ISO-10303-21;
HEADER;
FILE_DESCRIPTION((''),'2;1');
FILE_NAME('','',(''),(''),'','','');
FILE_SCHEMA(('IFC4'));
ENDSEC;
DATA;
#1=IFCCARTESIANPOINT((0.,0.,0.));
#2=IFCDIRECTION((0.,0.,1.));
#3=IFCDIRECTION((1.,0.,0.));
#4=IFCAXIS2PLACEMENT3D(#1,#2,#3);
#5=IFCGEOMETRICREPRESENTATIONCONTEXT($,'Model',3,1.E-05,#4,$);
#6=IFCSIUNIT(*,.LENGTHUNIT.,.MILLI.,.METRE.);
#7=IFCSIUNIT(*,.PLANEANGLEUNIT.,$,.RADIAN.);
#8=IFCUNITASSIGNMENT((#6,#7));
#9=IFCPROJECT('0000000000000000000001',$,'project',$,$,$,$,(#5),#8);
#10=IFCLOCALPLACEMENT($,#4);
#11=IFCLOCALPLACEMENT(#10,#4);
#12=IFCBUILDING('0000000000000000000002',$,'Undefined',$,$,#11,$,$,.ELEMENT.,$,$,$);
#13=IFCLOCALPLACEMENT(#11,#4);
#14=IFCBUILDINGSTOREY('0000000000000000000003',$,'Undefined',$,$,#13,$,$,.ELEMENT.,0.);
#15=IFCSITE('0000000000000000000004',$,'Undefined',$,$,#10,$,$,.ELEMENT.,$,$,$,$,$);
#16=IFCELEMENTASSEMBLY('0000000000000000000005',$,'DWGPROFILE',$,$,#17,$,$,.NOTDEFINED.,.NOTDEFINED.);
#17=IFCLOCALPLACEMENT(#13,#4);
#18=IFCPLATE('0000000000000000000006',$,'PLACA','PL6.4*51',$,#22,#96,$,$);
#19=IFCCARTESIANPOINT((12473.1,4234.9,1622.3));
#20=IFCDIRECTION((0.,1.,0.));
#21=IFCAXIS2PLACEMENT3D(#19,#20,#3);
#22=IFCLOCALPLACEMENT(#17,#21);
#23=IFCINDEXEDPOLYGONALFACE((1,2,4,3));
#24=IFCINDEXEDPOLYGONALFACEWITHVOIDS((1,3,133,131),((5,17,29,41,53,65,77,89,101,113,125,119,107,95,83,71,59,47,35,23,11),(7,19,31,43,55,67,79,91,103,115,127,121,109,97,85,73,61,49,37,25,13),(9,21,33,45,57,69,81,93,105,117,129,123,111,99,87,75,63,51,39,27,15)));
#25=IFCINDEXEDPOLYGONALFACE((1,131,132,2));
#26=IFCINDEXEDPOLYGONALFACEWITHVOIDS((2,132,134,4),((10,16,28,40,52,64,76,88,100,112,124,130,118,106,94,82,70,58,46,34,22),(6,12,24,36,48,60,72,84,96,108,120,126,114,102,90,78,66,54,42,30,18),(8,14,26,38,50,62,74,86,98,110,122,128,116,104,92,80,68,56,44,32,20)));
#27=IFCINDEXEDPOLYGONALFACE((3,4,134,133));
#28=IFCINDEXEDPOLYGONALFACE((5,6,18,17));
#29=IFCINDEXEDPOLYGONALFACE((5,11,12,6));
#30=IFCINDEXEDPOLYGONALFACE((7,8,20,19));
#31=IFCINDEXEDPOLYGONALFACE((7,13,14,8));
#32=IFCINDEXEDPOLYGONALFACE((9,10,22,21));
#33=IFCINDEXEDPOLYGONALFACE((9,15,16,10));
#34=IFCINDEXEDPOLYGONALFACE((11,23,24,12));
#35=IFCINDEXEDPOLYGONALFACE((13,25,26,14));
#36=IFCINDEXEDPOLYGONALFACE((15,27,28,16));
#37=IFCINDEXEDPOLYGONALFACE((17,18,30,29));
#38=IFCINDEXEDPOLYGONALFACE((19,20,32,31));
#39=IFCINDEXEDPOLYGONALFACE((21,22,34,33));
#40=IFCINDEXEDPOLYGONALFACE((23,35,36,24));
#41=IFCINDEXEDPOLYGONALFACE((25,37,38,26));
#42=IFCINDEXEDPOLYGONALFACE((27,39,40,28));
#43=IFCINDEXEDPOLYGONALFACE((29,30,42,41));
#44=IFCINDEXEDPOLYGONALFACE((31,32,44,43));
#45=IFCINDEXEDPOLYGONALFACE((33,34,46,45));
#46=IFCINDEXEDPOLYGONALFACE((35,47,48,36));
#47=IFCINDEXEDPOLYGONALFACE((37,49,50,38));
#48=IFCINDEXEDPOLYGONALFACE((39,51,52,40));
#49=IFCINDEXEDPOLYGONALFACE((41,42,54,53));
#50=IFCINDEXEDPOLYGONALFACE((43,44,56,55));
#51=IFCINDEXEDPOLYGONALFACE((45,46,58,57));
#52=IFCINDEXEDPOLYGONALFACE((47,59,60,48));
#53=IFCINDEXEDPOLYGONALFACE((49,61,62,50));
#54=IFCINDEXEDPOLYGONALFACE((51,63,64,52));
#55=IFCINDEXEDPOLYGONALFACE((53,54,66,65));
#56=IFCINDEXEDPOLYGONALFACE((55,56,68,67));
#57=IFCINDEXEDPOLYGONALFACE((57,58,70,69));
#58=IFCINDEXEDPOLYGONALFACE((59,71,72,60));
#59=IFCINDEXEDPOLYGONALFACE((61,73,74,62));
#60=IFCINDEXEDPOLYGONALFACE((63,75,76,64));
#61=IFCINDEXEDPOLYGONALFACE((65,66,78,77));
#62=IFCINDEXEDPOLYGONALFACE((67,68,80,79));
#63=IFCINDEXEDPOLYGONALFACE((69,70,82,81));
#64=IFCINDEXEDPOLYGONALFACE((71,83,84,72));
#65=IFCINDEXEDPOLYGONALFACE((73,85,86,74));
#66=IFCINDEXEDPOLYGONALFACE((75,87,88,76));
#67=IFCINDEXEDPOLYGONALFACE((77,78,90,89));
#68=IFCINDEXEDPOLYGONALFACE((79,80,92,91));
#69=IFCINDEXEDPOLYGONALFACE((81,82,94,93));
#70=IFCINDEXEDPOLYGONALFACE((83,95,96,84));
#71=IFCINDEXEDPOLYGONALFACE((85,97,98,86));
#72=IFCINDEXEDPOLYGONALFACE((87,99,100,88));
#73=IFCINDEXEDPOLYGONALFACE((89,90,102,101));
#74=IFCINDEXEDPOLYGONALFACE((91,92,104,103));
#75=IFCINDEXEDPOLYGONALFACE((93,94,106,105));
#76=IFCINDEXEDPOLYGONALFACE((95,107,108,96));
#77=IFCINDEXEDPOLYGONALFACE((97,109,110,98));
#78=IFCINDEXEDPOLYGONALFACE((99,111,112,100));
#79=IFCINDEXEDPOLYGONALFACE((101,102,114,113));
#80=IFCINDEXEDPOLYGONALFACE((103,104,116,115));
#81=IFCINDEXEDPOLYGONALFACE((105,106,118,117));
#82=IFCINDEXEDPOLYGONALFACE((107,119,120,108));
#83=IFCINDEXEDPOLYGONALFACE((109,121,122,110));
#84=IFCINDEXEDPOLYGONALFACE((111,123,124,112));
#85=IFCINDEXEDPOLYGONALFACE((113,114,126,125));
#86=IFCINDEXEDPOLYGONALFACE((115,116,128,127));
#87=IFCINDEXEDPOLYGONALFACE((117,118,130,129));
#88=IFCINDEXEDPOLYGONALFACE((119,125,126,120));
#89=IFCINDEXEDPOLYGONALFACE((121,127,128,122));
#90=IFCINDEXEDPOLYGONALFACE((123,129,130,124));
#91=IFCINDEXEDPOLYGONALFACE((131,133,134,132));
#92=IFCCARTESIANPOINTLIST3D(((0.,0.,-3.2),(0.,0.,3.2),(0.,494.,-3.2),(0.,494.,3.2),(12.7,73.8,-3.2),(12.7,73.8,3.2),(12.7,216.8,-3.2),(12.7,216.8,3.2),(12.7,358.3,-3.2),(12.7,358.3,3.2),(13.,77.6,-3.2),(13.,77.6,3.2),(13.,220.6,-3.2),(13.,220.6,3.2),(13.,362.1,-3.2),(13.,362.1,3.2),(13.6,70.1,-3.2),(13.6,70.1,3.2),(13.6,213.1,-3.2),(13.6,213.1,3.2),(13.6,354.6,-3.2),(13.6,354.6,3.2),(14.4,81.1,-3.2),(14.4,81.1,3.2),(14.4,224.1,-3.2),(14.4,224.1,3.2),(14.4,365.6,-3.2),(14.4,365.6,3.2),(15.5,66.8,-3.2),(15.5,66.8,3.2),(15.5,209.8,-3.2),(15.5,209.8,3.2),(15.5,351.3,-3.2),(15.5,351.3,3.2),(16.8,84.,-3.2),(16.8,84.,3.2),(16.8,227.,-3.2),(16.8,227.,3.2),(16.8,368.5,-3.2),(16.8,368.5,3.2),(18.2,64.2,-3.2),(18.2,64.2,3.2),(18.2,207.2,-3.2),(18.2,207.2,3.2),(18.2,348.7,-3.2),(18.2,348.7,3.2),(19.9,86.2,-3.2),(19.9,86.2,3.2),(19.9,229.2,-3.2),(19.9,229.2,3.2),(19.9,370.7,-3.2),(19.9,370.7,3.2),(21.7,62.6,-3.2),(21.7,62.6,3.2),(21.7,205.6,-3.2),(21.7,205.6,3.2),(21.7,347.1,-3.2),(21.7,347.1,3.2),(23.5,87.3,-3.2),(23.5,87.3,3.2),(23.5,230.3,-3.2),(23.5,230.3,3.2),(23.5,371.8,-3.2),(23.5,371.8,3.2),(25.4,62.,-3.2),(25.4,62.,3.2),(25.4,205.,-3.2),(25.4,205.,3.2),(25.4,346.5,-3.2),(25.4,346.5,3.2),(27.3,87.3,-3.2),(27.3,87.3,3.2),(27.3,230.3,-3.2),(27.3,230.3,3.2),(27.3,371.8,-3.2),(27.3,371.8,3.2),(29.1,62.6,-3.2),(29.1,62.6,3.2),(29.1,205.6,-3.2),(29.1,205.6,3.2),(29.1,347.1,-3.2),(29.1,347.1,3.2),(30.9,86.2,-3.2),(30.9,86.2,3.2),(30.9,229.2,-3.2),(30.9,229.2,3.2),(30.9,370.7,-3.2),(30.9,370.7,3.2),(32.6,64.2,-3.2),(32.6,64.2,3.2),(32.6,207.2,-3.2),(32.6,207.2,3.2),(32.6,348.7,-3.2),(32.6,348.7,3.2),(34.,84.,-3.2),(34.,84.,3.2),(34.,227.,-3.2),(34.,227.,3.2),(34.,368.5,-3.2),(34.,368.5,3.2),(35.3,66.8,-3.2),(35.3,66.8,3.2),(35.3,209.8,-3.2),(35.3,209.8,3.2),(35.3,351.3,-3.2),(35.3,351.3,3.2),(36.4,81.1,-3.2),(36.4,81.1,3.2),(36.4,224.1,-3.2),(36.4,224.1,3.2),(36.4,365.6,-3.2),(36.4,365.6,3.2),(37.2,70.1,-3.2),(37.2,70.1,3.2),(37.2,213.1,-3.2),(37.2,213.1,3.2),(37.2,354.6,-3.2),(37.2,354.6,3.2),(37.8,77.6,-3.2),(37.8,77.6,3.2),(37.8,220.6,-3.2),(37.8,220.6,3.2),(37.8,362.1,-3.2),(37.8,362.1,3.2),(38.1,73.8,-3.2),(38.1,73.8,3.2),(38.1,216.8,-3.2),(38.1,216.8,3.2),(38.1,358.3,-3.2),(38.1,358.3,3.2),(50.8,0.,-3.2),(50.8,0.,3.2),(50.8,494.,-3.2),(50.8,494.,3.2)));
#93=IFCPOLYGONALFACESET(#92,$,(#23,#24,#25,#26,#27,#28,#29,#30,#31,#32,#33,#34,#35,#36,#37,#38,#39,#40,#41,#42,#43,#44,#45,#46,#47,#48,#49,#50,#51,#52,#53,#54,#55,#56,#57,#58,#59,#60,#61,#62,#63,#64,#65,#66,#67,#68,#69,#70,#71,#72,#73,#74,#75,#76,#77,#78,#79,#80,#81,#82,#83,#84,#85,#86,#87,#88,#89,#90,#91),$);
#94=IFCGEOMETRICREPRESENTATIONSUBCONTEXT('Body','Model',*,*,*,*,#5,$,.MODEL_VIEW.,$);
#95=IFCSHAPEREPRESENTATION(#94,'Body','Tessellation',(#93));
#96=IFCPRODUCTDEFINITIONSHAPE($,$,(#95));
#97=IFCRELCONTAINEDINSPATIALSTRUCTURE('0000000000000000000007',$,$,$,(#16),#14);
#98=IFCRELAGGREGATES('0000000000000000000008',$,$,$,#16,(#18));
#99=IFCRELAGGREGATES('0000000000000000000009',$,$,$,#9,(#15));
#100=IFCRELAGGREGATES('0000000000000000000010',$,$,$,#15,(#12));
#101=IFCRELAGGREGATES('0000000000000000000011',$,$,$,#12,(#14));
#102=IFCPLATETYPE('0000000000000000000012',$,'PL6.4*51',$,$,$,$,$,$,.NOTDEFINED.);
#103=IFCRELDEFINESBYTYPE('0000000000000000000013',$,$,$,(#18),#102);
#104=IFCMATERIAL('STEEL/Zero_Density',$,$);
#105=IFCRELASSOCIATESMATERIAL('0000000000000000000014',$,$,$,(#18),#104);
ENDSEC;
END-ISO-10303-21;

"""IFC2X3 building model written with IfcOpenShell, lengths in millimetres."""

from ifc_helpers import new_model, si_unit, frame, origin_with_axes, origin_2d_with_axis, place, context, subcontext, project, spatial, polyline, circle, outline, extrude, boolean, material, type_object, element, aggregate, save


model = new_model("IFC2X3")

# Units and contexts
model_context = context("Model", 3, precision=1e-05, world=origin_with_axes())
body_context = subcontext(model_context, "Body", "Model", "MODEL_VIEW")
ifc_project = project(units=[si_unit("LENGTHUNIT", "METRE", prefix="MILLI"), si_unit("PLANEANGLEUNIT", "RADIAN")], contexts=[model_context])

# Site, building, storey
site_placement = place(None, origin_with_axes())
site = spatial("IfcSite", under=ifc_project, at=site_placement, Name="Undefined", CompositionType="ELEMENT")
building_placement = place(site_placement, origin_with_axes())
building = spatial("IfcBuilding", under=site, at=building_placement, Name="Undefined", CompositionType="ELEMENT")
storey_placement = place(building_placement, origin_with_axes())
storey = spatial("IfcBuildingStorey", under=building, at=storey_placement, Name="Undefined", CompositionType="ELEMENT", Elevation=0.0)

# Element assembly, plate
assembly_1_placement = place(storey_placement, origin_with_axes())
assembly_1 = element("IfcElementAssembly", 1, at=assembly_1_placement, inside=storey, Name="DWGPROFILE", AssemblyPlace="NOTDEFINED", PredefinedType="NOTDEFINED")
ifc_material_1 = material(Name="STEEL/Zero_Density")
plate_type_1 = type_object("IfcPlateType", Name="PL6.4*51", PredefinedType="NOTDEFINED")
plate_1_placement = place(assembly_1_placement, frame((12473.1, 4234.9, 1622.3), z_axis=(0.0, 1.0, 0.0), x_axis=(1.0, 0.0, 0.0)))
plate_1 = element("IfcPlate", 2, at=plate_1_placement, type_object=plate_type_1, material=ifc_material_1, Name="PLACA", Description="PL6.4*51", context=body_context, shape_type="CSG", body=[
    boolean("DIFFERENCE", boolean("DIFFERENCE", boolean("DIFFERENCE", extrude(outline(polyline([(0.0, 0.0), (50.8, 0.0), (50.8, 494.0), (0.0, 494.0), (0.0, 0.0)])), frame((0.0, 0.0, -3.2), z_axis=(0.0, 0.0, 1.0), x_axis=(1.0, 0.0, 0.0)), (0.0, 0.0, 1.0), 6.4), extrude(circle(Radius=12.7, at=origin_2d_with_axis()), frame((25.4, 74.7, 100.0), z_axis=(0.0, 0.000001, -1.0), x_axis=(0.0, -1.0, 0.0)), (0.0, 0.0, 1.0), 200.0)), extrude(circle(Radius=12.7, at=origin_2d_with_axis()), frame((25.4, 217.7, 100.0), z_axis=(0.0, 0.000001, -1.0), x_axis=(0.0, -1.0, 0.0)), (0.0, 0.0, 1.0), 200.0)), extrude(circle(Radius=12.7, at=origin_2d_with_axis()), frame((25.4, 359.2, 100.0), z_axis=(0.0, 0.000001, -1.0), x_axis=(0.0, -1.0, 0.0)), (0.0, 0.0, 1.0), 200.0)),
])
aggregate(assembly_1, [plate_1])

save(model, "model.ifc")
